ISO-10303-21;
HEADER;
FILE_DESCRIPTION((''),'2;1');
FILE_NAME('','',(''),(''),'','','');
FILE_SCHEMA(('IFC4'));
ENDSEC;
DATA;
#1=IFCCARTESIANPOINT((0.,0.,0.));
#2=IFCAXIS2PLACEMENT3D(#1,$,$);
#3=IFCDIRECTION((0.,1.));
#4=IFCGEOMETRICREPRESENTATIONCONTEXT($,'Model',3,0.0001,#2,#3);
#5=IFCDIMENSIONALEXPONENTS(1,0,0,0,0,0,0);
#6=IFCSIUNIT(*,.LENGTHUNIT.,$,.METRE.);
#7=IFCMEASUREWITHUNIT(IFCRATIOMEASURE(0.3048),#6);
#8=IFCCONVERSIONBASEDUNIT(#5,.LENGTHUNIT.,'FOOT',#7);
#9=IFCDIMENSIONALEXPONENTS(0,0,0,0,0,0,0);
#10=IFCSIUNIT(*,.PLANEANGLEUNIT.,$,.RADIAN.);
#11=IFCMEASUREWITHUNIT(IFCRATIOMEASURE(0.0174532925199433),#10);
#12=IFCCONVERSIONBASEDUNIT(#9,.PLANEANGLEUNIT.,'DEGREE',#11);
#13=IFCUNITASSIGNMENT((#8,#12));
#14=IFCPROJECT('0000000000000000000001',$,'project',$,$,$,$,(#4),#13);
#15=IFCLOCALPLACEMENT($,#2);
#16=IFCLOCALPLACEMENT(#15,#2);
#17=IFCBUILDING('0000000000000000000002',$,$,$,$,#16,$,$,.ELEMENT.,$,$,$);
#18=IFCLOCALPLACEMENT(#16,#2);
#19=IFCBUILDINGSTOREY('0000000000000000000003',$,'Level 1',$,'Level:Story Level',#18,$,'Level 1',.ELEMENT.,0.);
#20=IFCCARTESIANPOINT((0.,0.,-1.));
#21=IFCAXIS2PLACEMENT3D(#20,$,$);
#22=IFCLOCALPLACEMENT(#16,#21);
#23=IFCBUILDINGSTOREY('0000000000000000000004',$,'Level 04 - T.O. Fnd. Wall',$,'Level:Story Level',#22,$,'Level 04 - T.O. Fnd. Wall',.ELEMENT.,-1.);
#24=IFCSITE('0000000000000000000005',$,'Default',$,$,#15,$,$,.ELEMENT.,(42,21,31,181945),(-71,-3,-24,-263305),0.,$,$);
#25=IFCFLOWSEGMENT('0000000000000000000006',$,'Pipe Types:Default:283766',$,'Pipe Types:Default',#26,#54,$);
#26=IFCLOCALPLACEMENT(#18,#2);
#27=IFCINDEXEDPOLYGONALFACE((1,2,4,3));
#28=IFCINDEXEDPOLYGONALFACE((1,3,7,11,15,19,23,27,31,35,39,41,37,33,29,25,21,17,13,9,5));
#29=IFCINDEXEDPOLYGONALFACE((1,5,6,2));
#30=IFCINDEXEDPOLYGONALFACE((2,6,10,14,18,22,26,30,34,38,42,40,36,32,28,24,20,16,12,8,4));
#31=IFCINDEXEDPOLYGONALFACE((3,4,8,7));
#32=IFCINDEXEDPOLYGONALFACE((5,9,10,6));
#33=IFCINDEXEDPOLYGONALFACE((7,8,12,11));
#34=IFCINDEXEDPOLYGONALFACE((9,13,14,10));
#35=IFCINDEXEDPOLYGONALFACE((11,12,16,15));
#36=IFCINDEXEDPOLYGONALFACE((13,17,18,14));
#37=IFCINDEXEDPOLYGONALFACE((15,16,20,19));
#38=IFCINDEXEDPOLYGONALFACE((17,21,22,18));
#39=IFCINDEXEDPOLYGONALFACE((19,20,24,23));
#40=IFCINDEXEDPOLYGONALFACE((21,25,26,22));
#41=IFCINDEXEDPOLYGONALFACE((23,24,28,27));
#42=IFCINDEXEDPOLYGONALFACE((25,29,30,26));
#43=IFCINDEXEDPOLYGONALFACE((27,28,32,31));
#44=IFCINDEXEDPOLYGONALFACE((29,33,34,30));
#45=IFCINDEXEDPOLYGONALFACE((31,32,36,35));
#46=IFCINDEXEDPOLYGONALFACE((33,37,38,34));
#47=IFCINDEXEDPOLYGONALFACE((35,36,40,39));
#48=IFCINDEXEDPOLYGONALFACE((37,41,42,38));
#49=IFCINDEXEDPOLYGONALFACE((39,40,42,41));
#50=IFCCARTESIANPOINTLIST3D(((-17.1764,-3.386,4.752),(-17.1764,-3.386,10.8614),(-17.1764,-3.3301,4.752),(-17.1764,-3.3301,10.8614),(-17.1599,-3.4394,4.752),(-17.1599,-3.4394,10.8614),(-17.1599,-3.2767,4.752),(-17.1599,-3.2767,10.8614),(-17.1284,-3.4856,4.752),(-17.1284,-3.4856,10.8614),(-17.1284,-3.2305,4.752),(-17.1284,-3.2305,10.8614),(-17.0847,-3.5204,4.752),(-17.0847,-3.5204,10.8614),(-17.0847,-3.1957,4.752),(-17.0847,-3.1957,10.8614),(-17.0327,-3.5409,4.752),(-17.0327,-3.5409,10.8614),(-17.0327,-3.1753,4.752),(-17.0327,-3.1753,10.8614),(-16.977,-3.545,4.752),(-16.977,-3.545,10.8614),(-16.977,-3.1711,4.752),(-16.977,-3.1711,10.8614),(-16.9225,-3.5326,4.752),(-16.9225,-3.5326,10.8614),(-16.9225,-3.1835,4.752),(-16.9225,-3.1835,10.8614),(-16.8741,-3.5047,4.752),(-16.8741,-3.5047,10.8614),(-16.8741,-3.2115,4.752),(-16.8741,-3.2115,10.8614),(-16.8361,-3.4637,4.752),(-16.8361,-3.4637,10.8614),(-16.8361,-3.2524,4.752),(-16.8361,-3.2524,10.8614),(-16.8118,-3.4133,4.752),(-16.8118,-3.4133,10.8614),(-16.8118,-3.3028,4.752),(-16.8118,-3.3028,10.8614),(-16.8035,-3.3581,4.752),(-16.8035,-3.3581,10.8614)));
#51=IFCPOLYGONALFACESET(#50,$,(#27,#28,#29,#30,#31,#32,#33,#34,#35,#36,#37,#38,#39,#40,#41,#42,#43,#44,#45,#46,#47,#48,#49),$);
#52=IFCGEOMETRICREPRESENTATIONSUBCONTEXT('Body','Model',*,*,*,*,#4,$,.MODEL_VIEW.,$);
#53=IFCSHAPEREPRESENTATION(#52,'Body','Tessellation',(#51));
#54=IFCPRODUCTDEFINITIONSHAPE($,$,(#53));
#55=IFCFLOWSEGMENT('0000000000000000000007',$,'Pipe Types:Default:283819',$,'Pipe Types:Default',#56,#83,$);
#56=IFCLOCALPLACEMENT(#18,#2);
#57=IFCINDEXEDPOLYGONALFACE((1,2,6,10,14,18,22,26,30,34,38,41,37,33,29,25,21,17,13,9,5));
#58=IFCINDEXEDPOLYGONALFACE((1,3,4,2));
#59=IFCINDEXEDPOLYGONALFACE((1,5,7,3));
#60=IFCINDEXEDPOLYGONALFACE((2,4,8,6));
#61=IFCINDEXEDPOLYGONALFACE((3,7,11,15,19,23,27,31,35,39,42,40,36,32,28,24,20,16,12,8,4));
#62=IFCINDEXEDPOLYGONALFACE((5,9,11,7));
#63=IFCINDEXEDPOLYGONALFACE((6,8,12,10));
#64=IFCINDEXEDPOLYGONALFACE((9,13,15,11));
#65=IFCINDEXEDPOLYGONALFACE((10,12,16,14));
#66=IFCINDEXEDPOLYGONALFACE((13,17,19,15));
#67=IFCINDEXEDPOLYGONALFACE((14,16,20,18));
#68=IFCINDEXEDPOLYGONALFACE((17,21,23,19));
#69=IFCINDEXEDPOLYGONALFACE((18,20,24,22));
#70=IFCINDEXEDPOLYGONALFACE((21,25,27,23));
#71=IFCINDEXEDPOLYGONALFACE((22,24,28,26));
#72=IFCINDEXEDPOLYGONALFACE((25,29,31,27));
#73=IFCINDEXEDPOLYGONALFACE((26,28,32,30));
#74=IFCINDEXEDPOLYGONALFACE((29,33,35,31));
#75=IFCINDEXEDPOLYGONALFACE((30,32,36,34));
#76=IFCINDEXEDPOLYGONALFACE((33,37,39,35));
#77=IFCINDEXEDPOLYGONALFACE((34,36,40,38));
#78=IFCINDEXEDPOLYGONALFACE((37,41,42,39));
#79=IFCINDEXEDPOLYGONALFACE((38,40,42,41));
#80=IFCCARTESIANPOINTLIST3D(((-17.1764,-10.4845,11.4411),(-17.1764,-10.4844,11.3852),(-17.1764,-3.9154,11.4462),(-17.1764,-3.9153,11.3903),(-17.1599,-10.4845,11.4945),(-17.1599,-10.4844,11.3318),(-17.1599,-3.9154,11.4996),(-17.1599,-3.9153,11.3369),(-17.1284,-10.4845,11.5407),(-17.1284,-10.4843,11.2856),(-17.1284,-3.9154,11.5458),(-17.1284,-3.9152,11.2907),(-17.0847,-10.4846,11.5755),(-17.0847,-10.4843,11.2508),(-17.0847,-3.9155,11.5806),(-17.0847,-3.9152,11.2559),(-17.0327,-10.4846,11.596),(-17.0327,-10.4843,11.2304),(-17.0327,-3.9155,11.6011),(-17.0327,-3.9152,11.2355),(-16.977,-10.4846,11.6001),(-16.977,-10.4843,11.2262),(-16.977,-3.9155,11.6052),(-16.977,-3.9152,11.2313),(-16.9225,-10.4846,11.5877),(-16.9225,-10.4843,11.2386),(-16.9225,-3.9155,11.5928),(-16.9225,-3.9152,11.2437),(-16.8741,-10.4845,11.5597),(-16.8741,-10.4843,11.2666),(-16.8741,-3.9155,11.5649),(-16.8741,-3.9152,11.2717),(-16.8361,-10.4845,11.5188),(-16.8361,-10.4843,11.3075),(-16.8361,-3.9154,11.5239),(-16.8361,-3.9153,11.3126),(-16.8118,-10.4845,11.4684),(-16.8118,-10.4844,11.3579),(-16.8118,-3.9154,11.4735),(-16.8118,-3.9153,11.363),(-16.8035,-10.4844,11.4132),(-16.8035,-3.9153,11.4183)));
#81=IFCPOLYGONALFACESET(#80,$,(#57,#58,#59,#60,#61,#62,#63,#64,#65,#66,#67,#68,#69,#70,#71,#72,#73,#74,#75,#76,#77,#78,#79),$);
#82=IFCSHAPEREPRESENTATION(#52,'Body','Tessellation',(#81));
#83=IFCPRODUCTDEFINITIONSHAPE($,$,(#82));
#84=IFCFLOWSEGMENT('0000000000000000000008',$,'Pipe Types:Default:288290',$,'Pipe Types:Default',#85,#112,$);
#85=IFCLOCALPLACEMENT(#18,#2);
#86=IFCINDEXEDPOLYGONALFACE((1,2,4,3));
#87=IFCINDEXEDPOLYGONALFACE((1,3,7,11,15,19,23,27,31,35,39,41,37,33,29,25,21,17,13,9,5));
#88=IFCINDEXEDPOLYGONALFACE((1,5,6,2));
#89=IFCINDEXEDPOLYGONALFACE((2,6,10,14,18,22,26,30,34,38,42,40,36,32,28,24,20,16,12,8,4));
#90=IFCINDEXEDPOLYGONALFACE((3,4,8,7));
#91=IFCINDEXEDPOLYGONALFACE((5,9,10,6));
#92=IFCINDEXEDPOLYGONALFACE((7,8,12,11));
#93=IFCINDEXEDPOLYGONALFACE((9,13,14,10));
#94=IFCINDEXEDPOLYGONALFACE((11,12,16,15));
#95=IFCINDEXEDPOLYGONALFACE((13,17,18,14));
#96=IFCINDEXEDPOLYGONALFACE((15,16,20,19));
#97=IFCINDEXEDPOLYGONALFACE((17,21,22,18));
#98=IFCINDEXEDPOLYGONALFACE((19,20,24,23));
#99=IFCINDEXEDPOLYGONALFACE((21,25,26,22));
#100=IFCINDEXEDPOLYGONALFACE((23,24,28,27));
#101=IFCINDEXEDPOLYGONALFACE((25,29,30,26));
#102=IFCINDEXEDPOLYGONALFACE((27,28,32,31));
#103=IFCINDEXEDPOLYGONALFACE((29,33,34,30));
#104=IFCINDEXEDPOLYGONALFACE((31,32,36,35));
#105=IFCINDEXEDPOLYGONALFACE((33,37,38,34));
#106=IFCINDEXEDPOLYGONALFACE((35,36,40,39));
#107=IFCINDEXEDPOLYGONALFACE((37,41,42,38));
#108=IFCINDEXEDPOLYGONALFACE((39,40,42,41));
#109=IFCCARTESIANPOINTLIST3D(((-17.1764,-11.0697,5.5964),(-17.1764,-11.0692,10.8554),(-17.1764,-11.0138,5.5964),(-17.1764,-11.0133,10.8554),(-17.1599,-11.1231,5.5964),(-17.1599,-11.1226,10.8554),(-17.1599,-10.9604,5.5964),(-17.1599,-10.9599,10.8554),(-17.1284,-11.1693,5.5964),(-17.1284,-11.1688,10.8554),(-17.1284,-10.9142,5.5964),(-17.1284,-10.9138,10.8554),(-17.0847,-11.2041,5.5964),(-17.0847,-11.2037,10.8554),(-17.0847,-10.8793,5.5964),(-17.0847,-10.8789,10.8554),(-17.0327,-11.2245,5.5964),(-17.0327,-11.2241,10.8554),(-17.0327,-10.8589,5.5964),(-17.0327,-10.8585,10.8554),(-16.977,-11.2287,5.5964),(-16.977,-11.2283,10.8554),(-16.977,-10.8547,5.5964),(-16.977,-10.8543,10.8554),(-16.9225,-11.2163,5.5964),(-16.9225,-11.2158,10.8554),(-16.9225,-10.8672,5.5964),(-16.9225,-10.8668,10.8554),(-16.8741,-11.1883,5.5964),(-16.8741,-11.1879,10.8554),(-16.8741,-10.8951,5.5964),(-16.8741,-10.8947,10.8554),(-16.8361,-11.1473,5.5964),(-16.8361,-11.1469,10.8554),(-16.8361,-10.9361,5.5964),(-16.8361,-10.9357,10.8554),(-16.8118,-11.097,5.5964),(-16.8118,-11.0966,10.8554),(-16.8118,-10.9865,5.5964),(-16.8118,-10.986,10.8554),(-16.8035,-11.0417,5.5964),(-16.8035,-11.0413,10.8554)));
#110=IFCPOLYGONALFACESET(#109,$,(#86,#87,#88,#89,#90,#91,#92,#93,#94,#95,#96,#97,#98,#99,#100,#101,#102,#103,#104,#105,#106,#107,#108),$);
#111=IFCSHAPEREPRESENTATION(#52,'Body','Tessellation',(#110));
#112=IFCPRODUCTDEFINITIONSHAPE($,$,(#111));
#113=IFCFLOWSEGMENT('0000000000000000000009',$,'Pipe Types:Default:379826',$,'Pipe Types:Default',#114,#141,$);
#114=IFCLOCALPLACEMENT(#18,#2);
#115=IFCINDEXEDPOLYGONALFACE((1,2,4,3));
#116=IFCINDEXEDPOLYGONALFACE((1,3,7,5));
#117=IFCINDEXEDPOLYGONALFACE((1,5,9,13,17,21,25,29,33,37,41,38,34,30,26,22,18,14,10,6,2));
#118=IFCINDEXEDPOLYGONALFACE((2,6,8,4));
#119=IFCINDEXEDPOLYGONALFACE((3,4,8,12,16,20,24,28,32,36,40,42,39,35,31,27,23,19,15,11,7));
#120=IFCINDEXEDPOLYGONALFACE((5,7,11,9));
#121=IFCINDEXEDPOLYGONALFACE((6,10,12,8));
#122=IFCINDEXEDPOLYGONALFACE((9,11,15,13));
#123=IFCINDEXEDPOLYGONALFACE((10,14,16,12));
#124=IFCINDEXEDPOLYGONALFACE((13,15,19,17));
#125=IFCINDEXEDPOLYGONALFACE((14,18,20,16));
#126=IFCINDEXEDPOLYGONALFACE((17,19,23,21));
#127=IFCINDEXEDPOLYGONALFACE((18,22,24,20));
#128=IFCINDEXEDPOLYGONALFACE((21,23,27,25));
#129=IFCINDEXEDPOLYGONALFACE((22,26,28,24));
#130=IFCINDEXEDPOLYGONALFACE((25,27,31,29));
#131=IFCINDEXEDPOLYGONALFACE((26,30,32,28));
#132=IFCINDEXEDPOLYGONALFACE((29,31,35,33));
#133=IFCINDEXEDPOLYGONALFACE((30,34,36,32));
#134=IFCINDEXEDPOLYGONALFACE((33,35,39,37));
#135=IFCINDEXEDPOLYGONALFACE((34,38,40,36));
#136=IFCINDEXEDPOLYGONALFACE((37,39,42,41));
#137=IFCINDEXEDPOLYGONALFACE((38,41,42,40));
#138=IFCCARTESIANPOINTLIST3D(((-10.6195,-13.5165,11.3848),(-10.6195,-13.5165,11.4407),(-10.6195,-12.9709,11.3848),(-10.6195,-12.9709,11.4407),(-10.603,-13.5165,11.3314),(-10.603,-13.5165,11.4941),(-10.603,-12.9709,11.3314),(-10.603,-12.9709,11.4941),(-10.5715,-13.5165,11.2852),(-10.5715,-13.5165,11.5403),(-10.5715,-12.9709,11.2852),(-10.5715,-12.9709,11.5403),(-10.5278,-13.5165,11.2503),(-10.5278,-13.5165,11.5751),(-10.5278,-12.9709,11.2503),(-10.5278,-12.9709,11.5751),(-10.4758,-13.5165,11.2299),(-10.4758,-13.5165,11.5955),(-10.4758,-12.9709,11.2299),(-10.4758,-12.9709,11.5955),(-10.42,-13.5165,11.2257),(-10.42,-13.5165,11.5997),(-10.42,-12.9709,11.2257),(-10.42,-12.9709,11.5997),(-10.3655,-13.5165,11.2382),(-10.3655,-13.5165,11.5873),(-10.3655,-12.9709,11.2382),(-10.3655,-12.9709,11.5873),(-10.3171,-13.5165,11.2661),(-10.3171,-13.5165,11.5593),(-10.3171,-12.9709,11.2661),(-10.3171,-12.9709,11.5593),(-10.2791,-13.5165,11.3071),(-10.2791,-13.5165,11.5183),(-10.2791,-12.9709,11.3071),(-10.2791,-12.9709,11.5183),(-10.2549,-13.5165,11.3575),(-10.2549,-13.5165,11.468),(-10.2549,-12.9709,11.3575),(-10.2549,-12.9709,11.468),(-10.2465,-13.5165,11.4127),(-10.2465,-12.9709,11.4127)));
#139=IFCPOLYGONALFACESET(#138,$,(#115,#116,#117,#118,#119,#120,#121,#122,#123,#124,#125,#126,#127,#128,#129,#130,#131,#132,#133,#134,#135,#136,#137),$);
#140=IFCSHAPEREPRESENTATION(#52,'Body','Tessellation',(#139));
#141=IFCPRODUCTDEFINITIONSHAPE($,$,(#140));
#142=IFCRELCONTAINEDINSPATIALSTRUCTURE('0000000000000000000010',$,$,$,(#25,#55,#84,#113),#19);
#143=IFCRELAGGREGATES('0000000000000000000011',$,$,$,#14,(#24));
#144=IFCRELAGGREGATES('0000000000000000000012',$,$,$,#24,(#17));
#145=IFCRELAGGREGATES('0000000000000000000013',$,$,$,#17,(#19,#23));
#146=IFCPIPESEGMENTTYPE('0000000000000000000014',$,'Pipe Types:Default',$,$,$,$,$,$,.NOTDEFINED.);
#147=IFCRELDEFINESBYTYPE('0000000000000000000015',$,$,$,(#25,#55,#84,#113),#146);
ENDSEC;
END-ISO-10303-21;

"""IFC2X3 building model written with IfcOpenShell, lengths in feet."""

from ifc_helpers import new_model, entity, si_unit, converted_unit, direction, frame, origin, origin_2d_with_axis, place, context, subcontext, project, spatial, circle, extrude, type_object, element, save


model = new_model("IFC2X3")

# Units and contexts
model_context = context("Model", 3, precision=0.0001, world=origin(), true_north=direction((0.0, 1.0)))
body_context = subcontext(model_context, "Body", "Model", "MODEL_VIEW")
ifc_project = project(units=[converted_unit("LENGTHUNIT", "FOOT", entity("IfcRatioMeasure", 0.3048), si_unit("LENGTHUNIT", "METRE"), dimensions=[1, 0, 0, 0, 0, 0, 0]), converted_unit("PLANEANGLEUNIT", "DEGREE", entity("IfcRatioMeasure", 0.0174532925199433), si_unit("PLANEANGLEUNIT", "RADIAN"), dimensions=[0, 0, 0, 0, 0, 0, 0])], contexts=[model_context])

# Site, building, storey
site_placement = place(None, origin())
site = spatial("IfcSite", under=ifc_project, at=site_placement, Name="Default", CompositionType="ELEMENT", RefLatitude=(42, 21, 31, 181945), RefLongitude=(-71, -3, -24, -263305), RefElevation=0.0)
building_placement = place(site_placement, origin())
building = spatial("IfcBuilding", under=site, at=building_placement, CompositionType="ELEMENT")
storey_1_placement = place(building_placement, origin())
storey_1 = spatial("IfcBuildingStorey", under=building, at=storey_1_placement, Name="Level 1", ObjectType="Level:Story Level", LongName="Level 1", CompositionType="ELEMENT", Elevation=0.0)

# Shared definitions
storey_2_placement = place(building_placement, frame((0.0, 0.0, -1.0)))
storey_2 = spatial("IfcBuildingStorey", under=building, at=storey_2_placement, Name="Level 04 - T.O. Fnd. Wall", ObjectType="Level:Story Level", LongName="Level 04 - T.O. Fnd. Wall", CompositionType="ELEMENT", Elevation=-1.0)

# Flow segments
pipe_segment_type = type_object("IfcPipeSegmentType", Name="Pipe Types:Default", PredefinedType="NOTDEFINED")
flow_segment_1_placement = place(storey_1_placement, origin())
element("IfcFlowSegment", 1, at=flow_segment_1_placement, inside=storey_1, type_object=pipe_segment_type, Name="Pipe Types:Default:283766", ObjectType="Pipe Types:Default", context=body_context, shape_type="SweptSolid", body=[
    extrude(circle(Radius=0.1875, at=origin_2d_with_axis()), frame((-16.991, -3.3581, 4.752)), (0.0, 0.0, 1.0), 6.1094),
])
flow_segment_2_placement = place(storey_1_placement, origin())
element("IfcFlowSegment", 2, at=flow_segment_2_placement, inside=storey_1, type_object=pipe_segment_type, Name="Pipe Types:Default:283819", ObjectType="Pipe Types:Default", context=body_context, shape_type="SweptSolid", body=[
    extrude(circle(Radius=0.1875, at=origin_2d_with_axis()), frame((-16.991, -10.4844, 11.4132), z_axis=(0.0, 1.0, 0.000777), x_axis=(1.0, 0.0, 0.0)), (0.0, 0.0, 1.0), 6.5691),
])
flow_segment_3_placement = place(storey_1_placement, origin())
element("IfcFlowSegment", 3, at=flow_segment_3_placement, inside=storey_1, type_object=pipe_segment_type, Name="Pipe Types:Default:288290", ObjectType="Pipe Types:Default", context=body_context, shape_type="SweptSolid", body=[
    extrude(circle(Radius=0.1875, at=origin_2d_with_axis()), frame((-16.991, -11.0417, 5.5964), z_axis=(0.0, 0.000082, 1.0), x_axis=(1.0, 0.0, 0.0)), (0.0, 0.0, 1.0), 5.259),
])
flow_segment_4_placement = place(storey_1_placement, origin())
element("IfcFlowSegment", 4, at=flow_segment_4_placement, inside=storey_1, type_object=pipe_segment_type, Name="Pipe Types:Default:379826", ObjectType="Pipe Types:Default", context=body_context, shape_type="SweptSolid", body=[
    extrude(circle(Radius=0.1875, at=origin_2d_with_axis()), frame((-10.434, -13.5165, 11.4127), z_axis=(0.0, 1.0, 0.0), x_axis=(1.0, 0.0, 0.0)), (0.0, 0.0, 1.0), 0.5456),
])

save(model, "model.ifc")
